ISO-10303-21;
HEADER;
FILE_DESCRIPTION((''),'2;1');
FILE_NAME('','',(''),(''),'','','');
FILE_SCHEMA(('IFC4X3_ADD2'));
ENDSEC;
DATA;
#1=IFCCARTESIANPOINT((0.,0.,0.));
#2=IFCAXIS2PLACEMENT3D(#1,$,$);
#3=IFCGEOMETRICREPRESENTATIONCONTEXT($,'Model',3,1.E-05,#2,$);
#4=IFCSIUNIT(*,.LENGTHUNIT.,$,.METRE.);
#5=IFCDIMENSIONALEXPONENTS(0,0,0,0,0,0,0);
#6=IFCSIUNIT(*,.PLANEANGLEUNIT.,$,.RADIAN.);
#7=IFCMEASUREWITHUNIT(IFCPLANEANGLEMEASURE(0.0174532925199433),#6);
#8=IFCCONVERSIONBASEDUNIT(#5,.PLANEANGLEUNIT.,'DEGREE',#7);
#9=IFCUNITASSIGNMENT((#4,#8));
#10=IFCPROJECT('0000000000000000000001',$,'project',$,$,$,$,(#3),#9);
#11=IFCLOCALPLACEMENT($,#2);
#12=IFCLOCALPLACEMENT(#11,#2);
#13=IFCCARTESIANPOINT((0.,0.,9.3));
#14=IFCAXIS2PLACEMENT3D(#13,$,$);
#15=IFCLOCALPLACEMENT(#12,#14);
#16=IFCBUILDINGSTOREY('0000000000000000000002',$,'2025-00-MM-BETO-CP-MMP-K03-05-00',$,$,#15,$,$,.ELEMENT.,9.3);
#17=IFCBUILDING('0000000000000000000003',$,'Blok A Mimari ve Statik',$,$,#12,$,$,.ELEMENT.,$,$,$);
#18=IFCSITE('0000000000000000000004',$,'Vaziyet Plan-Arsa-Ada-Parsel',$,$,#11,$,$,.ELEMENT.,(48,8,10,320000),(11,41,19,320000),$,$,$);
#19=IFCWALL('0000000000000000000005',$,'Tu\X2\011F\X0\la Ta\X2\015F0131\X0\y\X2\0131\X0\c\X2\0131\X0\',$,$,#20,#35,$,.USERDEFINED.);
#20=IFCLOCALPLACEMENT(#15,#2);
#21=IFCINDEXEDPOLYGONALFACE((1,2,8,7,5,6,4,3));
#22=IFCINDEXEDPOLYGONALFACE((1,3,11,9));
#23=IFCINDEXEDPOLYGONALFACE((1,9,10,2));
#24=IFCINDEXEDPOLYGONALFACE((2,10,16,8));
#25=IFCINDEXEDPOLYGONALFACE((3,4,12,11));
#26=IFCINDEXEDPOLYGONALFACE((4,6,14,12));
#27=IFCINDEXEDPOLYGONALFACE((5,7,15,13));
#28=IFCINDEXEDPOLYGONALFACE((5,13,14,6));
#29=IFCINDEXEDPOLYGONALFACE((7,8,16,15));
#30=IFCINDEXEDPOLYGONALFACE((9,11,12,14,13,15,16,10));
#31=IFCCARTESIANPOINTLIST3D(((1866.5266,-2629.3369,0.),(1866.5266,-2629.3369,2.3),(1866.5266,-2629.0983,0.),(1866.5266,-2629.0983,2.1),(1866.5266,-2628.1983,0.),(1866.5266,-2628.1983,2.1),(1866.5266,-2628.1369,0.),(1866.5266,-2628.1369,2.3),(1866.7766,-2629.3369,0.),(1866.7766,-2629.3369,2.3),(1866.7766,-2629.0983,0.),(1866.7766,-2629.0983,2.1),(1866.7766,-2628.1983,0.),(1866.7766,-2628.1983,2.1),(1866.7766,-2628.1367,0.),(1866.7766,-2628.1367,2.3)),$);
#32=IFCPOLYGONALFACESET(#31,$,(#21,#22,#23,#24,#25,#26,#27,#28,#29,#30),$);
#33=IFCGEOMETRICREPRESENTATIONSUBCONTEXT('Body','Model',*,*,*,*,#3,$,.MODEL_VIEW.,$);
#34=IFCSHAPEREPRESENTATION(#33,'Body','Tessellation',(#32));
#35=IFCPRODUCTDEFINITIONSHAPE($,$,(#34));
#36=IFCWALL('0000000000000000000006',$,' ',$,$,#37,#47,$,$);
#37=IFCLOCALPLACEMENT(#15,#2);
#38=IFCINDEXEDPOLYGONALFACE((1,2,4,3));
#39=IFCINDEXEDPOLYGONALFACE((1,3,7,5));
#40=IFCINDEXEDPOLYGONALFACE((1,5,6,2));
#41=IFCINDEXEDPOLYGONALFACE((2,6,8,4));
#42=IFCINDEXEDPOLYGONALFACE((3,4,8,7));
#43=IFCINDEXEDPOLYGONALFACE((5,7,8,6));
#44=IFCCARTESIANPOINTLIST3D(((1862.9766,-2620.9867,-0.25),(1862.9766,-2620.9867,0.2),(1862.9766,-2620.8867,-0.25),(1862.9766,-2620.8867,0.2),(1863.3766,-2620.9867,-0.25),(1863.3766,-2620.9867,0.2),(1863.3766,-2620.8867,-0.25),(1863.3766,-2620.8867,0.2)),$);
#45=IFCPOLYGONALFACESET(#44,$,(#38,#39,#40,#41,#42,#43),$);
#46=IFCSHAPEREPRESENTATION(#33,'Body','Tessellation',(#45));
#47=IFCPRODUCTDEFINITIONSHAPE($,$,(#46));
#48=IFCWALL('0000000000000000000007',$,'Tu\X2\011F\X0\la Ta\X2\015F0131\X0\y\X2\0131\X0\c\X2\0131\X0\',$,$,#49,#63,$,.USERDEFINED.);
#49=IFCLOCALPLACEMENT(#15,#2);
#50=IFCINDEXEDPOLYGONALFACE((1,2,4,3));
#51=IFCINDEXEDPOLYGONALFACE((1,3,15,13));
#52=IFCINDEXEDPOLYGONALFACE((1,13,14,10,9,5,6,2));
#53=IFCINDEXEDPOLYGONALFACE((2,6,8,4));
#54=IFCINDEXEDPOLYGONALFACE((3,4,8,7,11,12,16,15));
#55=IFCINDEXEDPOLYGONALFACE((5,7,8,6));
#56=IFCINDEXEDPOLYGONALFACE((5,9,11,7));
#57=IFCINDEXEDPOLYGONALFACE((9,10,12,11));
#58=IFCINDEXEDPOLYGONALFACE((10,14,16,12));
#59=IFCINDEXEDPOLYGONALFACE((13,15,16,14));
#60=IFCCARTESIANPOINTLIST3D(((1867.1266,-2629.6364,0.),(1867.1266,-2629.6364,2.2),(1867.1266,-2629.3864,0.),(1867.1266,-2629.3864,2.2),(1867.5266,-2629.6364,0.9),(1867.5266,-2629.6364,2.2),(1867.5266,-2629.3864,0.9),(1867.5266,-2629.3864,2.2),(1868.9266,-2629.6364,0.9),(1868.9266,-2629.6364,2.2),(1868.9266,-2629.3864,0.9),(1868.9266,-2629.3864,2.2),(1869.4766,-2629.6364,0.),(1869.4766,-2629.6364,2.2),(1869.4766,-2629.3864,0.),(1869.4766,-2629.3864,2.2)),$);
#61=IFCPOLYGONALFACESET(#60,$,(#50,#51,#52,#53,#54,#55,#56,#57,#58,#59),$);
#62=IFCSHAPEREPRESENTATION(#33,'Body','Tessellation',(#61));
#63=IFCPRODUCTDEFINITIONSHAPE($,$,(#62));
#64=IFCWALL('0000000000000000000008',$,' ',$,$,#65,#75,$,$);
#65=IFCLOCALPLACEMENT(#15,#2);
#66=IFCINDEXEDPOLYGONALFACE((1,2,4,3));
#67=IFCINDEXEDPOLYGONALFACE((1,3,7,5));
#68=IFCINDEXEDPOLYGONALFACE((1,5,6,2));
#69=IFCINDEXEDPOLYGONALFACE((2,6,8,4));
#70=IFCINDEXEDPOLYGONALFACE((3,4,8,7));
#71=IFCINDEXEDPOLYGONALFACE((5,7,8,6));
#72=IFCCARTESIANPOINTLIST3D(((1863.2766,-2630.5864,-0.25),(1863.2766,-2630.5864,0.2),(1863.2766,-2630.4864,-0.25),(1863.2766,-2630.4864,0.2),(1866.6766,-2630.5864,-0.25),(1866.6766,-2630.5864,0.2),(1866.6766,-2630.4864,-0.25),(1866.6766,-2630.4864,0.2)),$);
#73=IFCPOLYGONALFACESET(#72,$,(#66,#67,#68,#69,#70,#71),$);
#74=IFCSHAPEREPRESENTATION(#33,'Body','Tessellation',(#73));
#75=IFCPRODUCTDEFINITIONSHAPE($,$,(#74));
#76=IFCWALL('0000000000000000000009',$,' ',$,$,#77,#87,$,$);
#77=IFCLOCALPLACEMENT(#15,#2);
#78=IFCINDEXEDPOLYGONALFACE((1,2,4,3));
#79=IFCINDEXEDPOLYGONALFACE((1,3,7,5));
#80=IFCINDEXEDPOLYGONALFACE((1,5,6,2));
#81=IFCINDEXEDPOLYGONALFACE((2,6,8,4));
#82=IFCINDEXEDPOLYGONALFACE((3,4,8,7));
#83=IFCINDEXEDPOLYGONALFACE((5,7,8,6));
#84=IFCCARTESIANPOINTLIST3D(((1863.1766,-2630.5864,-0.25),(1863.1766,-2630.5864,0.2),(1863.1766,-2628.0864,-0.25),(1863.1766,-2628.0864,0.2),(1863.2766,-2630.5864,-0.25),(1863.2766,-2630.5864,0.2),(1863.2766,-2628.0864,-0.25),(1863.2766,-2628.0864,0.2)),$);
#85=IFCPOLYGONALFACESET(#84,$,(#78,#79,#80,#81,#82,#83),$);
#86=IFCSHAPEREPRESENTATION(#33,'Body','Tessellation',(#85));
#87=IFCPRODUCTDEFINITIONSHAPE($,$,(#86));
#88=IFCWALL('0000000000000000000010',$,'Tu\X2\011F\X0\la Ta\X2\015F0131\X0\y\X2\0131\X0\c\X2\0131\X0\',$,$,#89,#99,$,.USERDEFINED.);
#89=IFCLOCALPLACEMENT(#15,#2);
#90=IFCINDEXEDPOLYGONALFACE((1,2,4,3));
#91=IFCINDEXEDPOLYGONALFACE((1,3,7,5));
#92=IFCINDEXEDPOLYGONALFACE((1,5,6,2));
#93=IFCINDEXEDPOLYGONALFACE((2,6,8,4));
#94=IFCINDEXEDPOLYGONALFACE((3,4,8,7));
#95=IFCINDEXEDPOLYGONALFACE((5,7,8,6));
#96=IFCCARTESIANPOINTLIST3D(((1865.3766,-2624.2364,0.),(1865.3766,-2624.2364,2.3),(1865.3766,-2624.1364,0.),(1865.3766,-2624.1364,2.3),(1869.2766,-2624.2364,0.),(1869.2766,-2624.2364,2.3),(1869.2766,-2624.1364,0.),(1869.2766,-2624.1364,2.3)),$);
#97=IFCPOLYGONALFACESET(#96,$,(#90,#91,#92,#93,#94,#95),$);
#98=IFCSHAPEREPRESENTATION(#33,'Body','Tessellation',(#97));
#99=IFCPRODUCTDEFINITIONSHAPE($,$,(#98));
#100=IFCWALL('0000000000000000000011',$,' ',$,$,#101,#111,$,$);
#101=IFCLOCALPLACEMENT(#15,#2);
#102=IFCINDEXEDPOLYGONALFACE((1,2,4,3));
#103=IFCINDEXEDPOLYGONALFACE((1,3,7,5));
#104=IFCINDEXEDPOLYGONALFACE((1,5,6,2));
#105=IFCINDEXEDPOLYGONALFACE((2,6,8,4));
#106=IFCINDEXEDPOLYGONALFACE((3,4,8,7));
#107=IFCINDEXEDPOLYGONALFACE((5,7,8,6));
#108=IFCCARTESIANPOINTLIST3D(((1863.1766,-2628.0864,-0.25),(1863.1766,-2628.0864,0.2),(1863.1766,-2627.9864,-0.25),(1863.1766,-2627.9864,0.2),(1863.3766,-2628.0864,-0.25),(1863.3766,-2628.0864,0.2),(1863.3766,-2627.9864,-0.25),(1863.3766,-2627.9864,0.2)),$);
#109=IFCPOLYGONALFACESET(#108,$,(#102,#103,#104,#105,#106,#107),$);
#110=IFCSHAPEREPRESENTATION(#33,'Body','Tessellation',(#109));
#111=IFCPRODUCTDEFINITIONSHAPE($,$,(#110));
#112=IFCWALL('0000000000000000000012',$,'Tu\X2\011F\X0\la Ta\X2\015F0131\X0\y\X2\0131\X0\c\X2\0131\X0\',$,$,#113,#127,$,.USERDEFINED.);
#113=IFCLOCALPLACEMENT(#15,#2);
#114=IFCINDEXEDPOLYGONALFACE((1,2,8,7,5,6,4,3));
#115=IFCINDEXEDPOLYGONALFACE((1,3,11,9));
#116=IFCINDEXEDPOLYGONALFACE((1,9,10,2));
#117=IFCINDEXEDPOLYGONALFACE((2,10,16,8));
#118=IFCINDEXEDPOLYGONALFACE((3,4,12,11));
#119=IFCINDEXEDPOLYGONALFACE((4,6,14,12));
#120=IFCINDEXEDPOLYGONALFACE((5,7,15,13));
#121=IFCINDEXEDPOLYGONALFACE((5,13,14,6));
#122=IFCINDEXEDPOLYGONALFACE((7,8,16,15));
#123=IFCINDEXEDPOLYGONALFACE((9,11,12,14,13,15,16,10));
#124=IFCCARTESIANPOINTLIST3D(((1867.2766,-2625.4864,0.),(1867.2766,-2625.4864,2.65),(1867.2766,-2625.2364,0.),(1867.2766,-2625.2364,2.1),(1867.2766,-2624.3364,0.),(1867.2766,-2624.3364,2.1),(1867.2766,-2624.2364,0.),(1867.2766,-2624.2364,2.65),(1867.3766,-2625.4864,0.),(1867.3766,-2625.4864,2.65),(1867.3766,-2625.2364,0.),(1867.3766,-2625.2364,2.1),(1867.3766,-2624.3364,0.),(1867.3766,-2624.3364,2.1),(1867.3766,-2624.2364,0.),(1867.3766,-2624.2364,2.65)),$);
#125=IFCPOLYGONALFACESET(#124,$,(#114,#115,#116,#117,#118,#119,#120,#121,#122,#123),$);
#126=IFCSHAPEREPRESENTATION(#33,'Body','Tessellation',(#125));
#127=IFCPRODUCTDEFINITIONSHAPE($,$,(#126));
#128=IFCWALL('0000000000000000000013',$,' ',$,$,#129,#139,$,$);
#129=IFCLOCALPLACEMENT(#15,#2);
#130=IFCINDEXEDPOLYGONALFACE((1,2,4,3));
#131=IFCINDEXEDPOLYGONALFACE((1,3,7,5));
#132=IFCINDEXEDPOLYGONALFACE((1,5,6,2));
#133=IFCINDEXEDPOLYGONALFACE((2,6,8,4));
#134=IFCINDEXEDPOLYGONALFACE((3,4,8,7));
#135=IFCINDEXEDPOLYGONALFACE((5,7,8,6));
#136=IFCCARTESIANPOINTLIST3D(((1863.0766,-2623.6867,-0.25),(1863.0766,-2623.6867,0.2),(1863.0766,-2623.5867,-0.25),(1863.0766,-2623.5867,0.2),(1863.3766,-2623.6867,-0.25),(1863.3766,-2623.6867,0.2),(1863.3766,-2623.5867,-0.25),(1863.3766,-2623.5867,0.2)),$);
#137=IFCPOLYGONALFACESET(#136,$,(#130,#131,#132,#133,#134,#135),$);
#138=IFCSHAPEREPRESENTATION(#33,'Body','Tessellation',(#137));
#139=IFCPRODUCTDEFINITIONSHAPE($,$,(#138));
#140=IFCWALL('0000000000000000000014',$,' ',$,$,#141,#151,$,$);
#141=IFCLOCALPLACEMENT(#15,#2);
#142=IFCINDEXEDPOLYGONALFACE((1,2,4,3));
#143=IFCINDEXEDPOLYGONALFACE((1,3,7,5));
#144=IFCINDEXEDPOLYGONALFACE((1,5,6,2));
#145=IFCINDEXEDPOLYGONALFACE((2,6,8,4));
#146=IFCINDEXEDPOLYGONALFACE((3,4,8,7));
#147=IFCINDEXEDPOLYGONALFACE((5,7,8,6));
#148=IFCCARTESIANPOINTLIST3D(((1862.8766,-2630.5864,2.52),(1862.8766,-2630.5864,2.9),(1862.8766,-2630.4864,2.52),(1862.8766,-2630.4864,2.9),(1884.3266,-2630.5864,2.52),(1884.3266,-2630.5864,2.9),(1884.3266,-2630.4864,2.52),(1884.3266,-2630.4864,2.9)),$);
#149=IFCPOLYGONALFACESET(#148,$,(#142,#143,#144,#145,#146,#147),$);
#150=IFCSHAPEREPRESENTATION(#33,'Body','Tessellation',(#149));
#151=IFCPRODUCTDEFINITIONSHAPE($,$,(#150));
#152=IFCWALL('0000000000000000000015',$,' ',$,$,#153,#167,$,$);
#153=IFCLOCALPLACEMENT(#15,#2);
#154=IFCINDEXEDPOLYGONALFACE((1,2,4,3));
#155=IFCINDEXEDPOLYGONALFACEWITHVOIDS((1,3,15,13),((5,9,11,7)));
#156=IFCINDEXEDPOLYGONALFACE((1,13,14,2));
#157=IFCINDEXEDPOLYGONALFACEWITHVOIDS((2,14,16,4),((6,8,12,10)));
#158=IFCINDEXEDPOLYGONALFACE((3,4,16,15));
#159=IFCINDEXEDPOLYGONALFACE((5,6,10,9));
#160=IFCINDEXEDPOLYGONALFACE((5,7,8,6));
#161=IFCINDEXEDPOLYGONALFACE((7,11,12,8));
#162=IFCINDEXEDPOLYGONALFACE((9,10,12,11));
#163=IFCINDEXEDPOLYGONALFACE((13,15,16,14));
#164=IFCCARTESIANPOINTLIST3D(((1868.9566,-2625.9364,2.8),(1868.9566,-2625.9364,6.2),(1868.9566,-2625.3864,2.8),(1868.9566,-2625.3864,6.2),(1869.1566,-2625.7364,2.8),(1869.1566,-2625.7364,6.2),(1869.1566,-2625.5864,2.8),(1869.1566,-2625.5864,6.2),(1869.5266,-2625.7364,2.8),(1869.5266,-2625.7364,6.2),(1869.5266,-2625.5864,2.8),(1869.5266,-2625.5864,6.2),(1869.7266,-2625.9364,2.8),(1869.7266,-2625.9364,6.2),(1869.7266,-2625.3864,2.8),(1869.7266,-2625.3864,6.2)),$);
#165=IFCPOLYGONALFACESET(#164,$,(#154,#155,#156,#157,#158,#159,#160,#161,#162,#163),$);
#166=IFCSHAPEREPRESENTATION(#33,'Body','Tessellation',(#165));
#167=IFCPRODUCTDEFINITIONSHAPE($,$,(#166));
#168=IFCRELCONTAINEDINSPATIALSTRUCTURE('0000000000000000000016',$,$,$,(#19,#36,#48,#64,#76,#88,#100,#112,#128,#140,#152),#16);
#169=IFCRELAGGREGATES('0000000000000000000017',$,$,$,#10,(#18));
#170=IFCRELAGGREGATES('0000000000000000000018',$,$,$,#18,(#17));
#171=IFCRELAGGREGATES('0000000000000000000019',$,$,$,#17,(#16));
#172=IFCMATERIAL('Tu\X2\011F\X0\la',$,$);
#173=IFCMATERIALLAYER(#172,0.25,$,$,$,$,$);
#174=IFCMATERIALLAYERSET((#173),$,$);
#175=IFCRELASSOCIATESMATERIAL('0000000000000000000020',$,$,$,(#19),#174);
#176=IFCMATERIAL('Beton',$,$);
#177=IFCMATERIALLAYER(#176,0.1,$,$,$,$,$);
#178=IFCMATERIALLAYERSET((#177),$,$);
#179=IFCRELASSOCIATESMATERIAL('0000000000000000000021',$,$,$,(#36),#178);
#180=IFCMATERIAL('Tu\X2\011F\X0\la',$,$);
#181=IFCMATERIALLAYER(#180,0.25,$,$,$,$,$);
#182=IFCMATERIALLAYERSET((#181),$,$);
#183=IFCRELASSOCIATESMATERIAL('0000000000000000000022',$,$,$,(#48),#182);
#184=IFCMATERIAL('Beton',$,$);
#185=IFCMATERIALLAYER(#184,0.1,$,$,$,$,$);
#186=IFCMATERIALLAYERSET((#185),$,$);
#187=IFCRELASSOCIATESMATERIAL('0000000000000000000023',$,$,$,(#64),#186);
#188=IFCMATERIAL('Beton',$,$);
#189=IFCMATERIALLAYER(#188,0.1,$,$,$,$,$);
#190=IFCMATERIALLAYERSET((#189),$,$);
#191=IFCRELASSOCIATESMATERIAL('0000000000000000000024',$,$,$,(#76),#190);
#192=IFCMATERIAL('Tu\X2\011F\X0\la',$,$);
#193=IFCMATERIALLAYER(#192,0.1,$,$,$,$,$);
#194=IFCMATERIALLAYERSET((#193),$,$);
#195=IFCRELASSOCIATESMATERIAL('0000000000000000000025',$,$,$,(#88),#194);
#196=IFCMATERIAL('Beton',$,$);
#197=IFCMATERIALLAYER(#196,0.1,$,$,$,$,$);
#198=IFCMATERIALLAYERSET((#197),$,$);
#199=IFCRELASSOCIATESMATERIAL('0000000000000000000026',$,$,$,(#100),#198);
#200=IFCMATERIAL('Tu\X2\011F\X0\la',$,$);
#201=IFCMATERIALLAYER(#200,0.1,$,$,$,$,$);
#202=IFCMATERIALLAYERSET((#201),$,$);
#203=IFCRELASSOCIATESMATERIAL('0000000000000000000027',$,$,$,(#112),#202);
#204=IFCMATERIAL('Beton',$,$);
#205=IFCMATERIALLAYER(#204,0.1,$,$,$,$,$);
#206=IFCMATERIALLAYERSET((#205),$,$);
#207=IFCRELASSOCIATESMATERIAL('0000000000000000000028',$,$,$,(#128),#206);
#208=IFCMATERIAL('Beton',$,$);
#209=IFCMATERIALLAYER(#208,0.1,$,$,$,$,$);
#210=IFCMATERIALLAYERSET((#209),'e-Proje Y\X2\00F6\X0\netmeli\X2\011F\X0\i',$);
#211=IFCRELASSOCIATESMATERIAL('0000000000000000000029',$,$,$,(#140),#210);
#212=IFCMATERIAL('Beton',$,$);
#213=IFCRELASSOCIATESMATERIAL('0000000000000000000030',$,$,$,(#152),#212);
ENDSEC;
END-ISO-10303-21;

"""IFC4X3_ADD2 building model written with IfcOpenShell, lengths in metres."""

from ifc_helpers import new_model, entity, si_unit, converted_unit, frame, frame_2d, origin, origin_with_axes, place, context, subcontext, project, spatial, polyline, rectangle, outline, extrude, material, layer, layer_set, layer_usage, element, save


model = new_model("IFC4X3_ADD2")

# Units and contexts
model_context = context("Model", 3, precision=1e-05, world=origin())
body_context = subcontext(model_context, "Body", "Model", "MODEL_VIEW")
ifc_project = project(units=[si_unit("LENGTHUNIT", "METRE"), converted_unit("PLANEANGLEUNIT", "DEGREE", entity("IfcPlaneAngleMeasure", 0.0174532925199433), si_unit("PLANEANGLEUNIT", "RADIAN"), dimensions=[0, 0, 0, 0, 0, 0, 0])], contexts=[model_context])

# Site, building, storey
site_placement = place(None, origin())
site = spatial("IfcSite", under=ifc_project, at=site_placement, Name="Vaziyet Plan-Arsa-Ada-Parsel", CompositionType="ELEMENT", RefLatitude=(48, 8, 10, 320000), RefLongitude=(11, 41, 19, 320000))
building_placement = place(site_placement, origin())
building = spatial("IfcBuilding", under=site, at=building_placement, Name="Blok A Mimari ve Statik", CompositionType="ELEMENT")
storey_placement = place(building_placement, frame((0.0, 0.0, 9.3)))
storey = spatial("IfcBuildingStorey", under=building, at=storey_placement, Name="2025-00-MM-BETO-CP-MMP-K03-05-00", CompositionType="ELEMENT", Elevation=9.3)

# Wall, opening
ifc_material_1 = material(Name="Tuğla")
ifc_layer_1 = layer(ifc_material_1, 0.25)
ifc_layer_set_1 = layer_set([ifc_layer_1])
ifc_layer_usage_1 = layer_usage(ifc_layer_set_1, "AXIS2", "POSITIVE", 0.0)
wall_1_placement = place(storey_placement, frame((1866.5266, -2628.1369, 0.0), z_axis=(0.0, 0.0, 1.0), x_axis=(0.0, -1.0, 0.0)))
wall_1 = element("IfcWall", 1, at=wall_1_placement, inside=storey, material=ifc_layer_usage_1, Name="Tuğla Taşıyıcı", PredefinedType="USERDEFINED", context=body_context, shape_type="SweptSolid", body=[
    extrude(outline(polyline([(-1.2, 0.0), (0.0, 0.0), (0.0, 0.25), (-1.2001, 0.25), (-1.2, 0.0)])), frame((1.2, 0.0, 0.0), z_axis=(0.0, 0.0, 1.0), x_axis=(1.0, 0.0, 0.0)), (0.0, 0.0, 1.0), 2.3),
])
opening_1_placement = place(wall_1_placement, frame((0.0614, 0.0, 0.0), z_axis=(0.0, 1.0, 0.0), x_axis=(0.0, 0.0, 1.0)))
element("IfcOpeningElement", 2, at=opening_1_placement, cuts=wall_1, PredefinedType="OPENING", context=body_context, shape_type="SweptSolid", body=[
    extrude(outline(polyline([(2.1, 0.9), (2.1, 0.0), (0.0, 0.0), (0.0, 0.9), (2.1, 0.9)])), origin_with_axes(), (0.0, 0.0, 1.0), 0.25),
])

# Wall
ifc_material_2 = material(Name="Beton")
ifc_layer_2 = layer(ifc_material_2, 0.1)
ifc_layer_set_2 = layer_set([ifc_layer_2])
ifc_layer_usage_2 = layer_usage(ifc_layer_set_2, "AXIS2", "POSITIVE", 0.0)
wall_2_placement = place(storey_placement, frame((1863.3766, -2620.8867, -0.25), z_axis=(0.0, 0.0, 1.0), x_axis=(-1.0, 0.0, 0.0)))
element("IfcWall", 3, at=wall_2_placement, inside=storey, material=ifc_layer_usage_2, Name=" ", context=body_context, shape_type="SweptSolid", body=[
    extrude(rectangle(XDim=0.4, YDim=0.1, at=frame_2d((0.2, 0.05), x_axis=(1.0, 0.0))), origin_with_axes(), (0.0, 0.0, 1.0), 0.45),
])

# Wall, opening
ifc_material_3 = material(Name="Tuğla")
ifc_layer_3 = layer(ifc_material_3, 0.25)
ifc_layer_set_3 = layer_set([ifc_layer_3])
ifc_layer_usage_3 = layer_usage(ifc_layer_set_3, "AXIS2", "POSITIVE", 0.0)
wall_3_placement = place(storey_placement, frame((1867.1266, -2629.6364, 0.0)))
wall_3 = element("IfcWall", 4, at=wall_3_placement, inside=storey, material=ifc_layer_usage_3, Name="Tuğla Taşıyıcı", PredefinedType="USERDEFINED", context=body_context, shape_type="SweptSolid", body=[
    extrude(rectangle(XDim=2.35, YDim=0.25, at=frame_2d((1.175, 0.125), x_axis=(1.0, 0.0))), origin_with_axes(), (0.0, 0.0, 1.0), 2.2),
])
opening_2_placement = place(wall_3_placement, frame((0.4, 0.0, 0.9), z_axis=(0.0, 1.0, 0.0), x_axis=(0.0, 0.0, 1.0)))
element("IfcOpeningElement", 5, at=opening_2_placement, cuts=wall_3, PredefinedType="OPENING", context=body_context, shape_type="SweptSolid", body=[
    extrude(outline(polyline([(1.35, 1.4), (1.35, 0.0), (0.0, 0.0), (0.0, 1.4), (1.35, 1.4)])), origin_with_axes(), (0.0, 0.0, 1.0), 0.25),
])

# Walls
ifc_material_4 = material(Name="Beton")
ifc_layer_4 = layer(ifc_material_4, 0.1)
ifc_layer_set_4 = layer_set([ifc_layer_4])
ifc_layer_usage_4 = layer_usage(ifc_layer_set_4, "AXIS2", "POSITIVE", 0.0)
wall_4_placement = place(storey_placement, frame((1863.2766, -2630.5864, -0.25)))
element("IfcWall", 6, at=wall_4_placement, inside=storey, material=ifc_layer_usage_4, Name=" ", context=body_context, shape_type="SweptSolid", body=[
    extrude(rectangle(XDim=3.4, YDim=0.1, at=frame_2d((1.7, 0.05), x_axis=(1.0, 0.0))), origin_with_axes(), (0.0, 0.0, 1.0), 0.45),
])
ifc_material_5 = material(Name="Beton")
ifc_layer_5 = layer(ifc_material_5, 0.1)
ifc_layer_set_5 = layer_set([ifc_layer_5])
ifc_layer_usage_5 = layer_usage(ifc_layer_set_5, "AXIS2", "POSITIVE", 0.0)
wall_5_placement = place(storey_placement, frame((1863.1766, -2628.0864, -0.25), z_axis=(0.0, 0.0, 1.0), x_axis=(0.0, -1.0, 0.0)))
element("IfcWall", 7, at=wall_5_placement, inside=storey, material=ifc_layer_usage_5, Name=" ", context=body_context, shape_type="SweptSolid", body=[
    extrude(rectangle(XDim=2.5, YDim=0.1, at=frame_2d((1.25, 0.05), x_axis=(1.0, 0.0))), origin_with_axes(), (0.0, 0.0, 1.0), 0.45),
])
ifc_material_6 = material(Name="Tuğla")
ifc_layer_6 = layer(ifc_material_6, 0.1)
ifc_layer_set_6 = layer_set([ifc_layer_6])
ifc_layer_usage_6 = layer_usage(ifc_layer_set_6, "AXIS2", "POSITIVE", 0.0)
wall_6_placement = place(storey_placement, frame((1865.3766, -2624.2364, 0.0), z_axis=(0.0, 0.0, 1.0), x_axis=(1.0, 0.0, 0.0)))
element("IfcWall", 8, at=wall_6_placement, inside=storey, material=ifc_layer_usage_6, Name="Tuğla Taşıyıcı", PredefinedType="USERDEFINED", context=body_context, shape_type="SweptSolid", body=[
    extrude(rectangle(XDim=3.9, YDim=0.1, at=frame_2d((1.95, 0.05), x_axis=(1.0, 0.0))), origin_with_axes(), (0.0, 0.0, 1.0), 2.3),
])
ifc_material_7 = material(Name="Beton")
ifc_layer_7 = layer(ifc_material_7, 0.1)
ifc_layer_set_7 = layer_set([ifc_layer_7])
ifc_layer_usage_7 = layer_usage(ifc_layer_set_7, "AXIS2", "POSITIVE", 0.0)
wall_7_placement = place(storey_placement, frame((1863.3766, -2627.9864, -0.25), z_axis=(0.0, 0.0, 1.0), x_axis=(-1.0, 0.0, 0.0)))
element("IfcWall", 9, at=wall_7_placement, inside=storey, material=ifc_layer_usage_7, Name=" ", context=body_context, shape_type="SweptSolid", body=[
    extrude(rectangle(XDim=0.2, YDim=0.1, at=frame_2d((0.1, 0.05), x_axis=(1.0, 0.0))), origin_with_axes(), (0.0, 0.0, 1.0), 0.45),
])

# Wall, opening
ifc_material_8 = material(Name="Tuğla")
ifc_layer_8 = layer(ifc_material_8, 0.1)
ifc_layer_set_8 = layer_set([ifc_layer_8])
ifc_layer_usage_8 = layer_usage(ifc_layer_set_8, "AXIS2", "POSITIVE", 0.0)
wall_8_placement = place(storey_placement, frame((1867.3766, -2625.4864, 0.0), z_axis=(0.0, 0.0, 1.0), x_axis=(0.0, 1.0, 0.0)))
wall_8 = element("IfcWall", 10, at=wall_8_placement, inside=storey, material=ifc_layer_usage_8, Name="Tuğla Taşıyıcı", PredefinedType="USERDEFINED", context=body_context, shape_type="SweptSolid", body=[
    extrude(rectangle(XDim=1.25, YDim=0.1, at=frame_2d((0.625, 0.05), x_axis=(1.0, 0.0))), origin_with_axes(), (0.0, 0.0, 1.0), 2.65),
])
opening_3_placement = place(wall_8_placement, frame((1.15, 0.1, 0.0), z_axis=(0.0, -1.0, 0.0), x_axis=(0.0, 0.0, 1.0)))
element("IfcOpeningElement", 11, at=opening_3_placement, cuts=wall_8, PredefinedType="OPENING", context=body_context, shape_type="SweptSolid", body=[
    extrude(outline(polyline([(2.1, 0.9), (2.1, 0.0), (0.0, 0.0), (0.0, 0.9), (2.1, 0.9)])), origin_with_axes(), (0.0, 0.0, 1.0), 0.1),
])

# Walls
ifc_material_9 = material(Name="Beton")
ifc_layer_9 = layer(ifc_material_9, 0.1)
ifc_layer_set_9 = layer_set([ifc_layer_9])
ifc_layer_usage_9 = layer_usage(ifc_layer_set_9, "AXIS2", "POSITIVE", 0.0)
wall_9_placement = place(storey_placement, frame((1863.0766, -2623.6867, -0.25)))
element("IfcWall", 12, at=wall_9_placement, inside=storey, material=ifc_layer_usage_9, Name=" ", context=body_context, shape_type="SweptSolid", body=[
    extrude(rectangle(XDim=0.3, YDim=0.1, at=frame_2d((0.15, 0.05), x_axis=(1.0, 0.0))), origin_with_axes(), (0.0, 0.0, 1.0), 0.45),
])
ifc_material_10 = material(Name="Beton")
ifc_layer_10 = layer(ifc_material_10, 0.1)
ifc_layer_set_10 = layer_set([ifc_layer_10], Name="e-Proje Yönetmeliği")
ifc_layer_usage_10 = layer_usage(ifc_layer_set_10, "AXIS2", "POSITIVE", 0.0)
wall_10_placement = place(storey_placement, frame((1862.8766, -2630.5864, 2.52), z_axis=(0.0, 0.0, 1.0), x_axis=(1.0, 0.0, 0.0)))
element("IfcWall", 13, at=wall_10_placement, inside=storey, material=ifc_layer_usage_10, Name=" ", context=body_context, shape_type="SweptSolid", body=[
    extrude(rectangle(XDim=21.45, YDim=0.1, at=frame_2d((10.725, 0.05), x_axis=(1.0, 0.0))), origin_with_axes(), (0.0, 0.0, 1.0), 0.38),
])
ifc_material_11 = material(Name="Beton")
wall_11_placement = place(storey_placement, frame((1868.9566, -2625.9364, 2.8)))
element("IfcWall", 14, at=wall_11_placement, inside=storey, material=ifc_material_11, Name=" ", context=body_context, shape_type="SweptSolid", body=[
    extrude(outline(polyline([(0.0, 0.0), (0.77, 0.0), (0.77, 0.55), (0.0, 0.55), (0.0, 0.0)]), holes=[polyline([(0.2, 0.2), (0.2, 0.35), (0.57, 0.35), (0.57, 0.2), (0.2, 0.2)])]), origin_with_axes(), (0.0, 0.0, 1.0), 3.4),
])

save(model, "model.ifc")
